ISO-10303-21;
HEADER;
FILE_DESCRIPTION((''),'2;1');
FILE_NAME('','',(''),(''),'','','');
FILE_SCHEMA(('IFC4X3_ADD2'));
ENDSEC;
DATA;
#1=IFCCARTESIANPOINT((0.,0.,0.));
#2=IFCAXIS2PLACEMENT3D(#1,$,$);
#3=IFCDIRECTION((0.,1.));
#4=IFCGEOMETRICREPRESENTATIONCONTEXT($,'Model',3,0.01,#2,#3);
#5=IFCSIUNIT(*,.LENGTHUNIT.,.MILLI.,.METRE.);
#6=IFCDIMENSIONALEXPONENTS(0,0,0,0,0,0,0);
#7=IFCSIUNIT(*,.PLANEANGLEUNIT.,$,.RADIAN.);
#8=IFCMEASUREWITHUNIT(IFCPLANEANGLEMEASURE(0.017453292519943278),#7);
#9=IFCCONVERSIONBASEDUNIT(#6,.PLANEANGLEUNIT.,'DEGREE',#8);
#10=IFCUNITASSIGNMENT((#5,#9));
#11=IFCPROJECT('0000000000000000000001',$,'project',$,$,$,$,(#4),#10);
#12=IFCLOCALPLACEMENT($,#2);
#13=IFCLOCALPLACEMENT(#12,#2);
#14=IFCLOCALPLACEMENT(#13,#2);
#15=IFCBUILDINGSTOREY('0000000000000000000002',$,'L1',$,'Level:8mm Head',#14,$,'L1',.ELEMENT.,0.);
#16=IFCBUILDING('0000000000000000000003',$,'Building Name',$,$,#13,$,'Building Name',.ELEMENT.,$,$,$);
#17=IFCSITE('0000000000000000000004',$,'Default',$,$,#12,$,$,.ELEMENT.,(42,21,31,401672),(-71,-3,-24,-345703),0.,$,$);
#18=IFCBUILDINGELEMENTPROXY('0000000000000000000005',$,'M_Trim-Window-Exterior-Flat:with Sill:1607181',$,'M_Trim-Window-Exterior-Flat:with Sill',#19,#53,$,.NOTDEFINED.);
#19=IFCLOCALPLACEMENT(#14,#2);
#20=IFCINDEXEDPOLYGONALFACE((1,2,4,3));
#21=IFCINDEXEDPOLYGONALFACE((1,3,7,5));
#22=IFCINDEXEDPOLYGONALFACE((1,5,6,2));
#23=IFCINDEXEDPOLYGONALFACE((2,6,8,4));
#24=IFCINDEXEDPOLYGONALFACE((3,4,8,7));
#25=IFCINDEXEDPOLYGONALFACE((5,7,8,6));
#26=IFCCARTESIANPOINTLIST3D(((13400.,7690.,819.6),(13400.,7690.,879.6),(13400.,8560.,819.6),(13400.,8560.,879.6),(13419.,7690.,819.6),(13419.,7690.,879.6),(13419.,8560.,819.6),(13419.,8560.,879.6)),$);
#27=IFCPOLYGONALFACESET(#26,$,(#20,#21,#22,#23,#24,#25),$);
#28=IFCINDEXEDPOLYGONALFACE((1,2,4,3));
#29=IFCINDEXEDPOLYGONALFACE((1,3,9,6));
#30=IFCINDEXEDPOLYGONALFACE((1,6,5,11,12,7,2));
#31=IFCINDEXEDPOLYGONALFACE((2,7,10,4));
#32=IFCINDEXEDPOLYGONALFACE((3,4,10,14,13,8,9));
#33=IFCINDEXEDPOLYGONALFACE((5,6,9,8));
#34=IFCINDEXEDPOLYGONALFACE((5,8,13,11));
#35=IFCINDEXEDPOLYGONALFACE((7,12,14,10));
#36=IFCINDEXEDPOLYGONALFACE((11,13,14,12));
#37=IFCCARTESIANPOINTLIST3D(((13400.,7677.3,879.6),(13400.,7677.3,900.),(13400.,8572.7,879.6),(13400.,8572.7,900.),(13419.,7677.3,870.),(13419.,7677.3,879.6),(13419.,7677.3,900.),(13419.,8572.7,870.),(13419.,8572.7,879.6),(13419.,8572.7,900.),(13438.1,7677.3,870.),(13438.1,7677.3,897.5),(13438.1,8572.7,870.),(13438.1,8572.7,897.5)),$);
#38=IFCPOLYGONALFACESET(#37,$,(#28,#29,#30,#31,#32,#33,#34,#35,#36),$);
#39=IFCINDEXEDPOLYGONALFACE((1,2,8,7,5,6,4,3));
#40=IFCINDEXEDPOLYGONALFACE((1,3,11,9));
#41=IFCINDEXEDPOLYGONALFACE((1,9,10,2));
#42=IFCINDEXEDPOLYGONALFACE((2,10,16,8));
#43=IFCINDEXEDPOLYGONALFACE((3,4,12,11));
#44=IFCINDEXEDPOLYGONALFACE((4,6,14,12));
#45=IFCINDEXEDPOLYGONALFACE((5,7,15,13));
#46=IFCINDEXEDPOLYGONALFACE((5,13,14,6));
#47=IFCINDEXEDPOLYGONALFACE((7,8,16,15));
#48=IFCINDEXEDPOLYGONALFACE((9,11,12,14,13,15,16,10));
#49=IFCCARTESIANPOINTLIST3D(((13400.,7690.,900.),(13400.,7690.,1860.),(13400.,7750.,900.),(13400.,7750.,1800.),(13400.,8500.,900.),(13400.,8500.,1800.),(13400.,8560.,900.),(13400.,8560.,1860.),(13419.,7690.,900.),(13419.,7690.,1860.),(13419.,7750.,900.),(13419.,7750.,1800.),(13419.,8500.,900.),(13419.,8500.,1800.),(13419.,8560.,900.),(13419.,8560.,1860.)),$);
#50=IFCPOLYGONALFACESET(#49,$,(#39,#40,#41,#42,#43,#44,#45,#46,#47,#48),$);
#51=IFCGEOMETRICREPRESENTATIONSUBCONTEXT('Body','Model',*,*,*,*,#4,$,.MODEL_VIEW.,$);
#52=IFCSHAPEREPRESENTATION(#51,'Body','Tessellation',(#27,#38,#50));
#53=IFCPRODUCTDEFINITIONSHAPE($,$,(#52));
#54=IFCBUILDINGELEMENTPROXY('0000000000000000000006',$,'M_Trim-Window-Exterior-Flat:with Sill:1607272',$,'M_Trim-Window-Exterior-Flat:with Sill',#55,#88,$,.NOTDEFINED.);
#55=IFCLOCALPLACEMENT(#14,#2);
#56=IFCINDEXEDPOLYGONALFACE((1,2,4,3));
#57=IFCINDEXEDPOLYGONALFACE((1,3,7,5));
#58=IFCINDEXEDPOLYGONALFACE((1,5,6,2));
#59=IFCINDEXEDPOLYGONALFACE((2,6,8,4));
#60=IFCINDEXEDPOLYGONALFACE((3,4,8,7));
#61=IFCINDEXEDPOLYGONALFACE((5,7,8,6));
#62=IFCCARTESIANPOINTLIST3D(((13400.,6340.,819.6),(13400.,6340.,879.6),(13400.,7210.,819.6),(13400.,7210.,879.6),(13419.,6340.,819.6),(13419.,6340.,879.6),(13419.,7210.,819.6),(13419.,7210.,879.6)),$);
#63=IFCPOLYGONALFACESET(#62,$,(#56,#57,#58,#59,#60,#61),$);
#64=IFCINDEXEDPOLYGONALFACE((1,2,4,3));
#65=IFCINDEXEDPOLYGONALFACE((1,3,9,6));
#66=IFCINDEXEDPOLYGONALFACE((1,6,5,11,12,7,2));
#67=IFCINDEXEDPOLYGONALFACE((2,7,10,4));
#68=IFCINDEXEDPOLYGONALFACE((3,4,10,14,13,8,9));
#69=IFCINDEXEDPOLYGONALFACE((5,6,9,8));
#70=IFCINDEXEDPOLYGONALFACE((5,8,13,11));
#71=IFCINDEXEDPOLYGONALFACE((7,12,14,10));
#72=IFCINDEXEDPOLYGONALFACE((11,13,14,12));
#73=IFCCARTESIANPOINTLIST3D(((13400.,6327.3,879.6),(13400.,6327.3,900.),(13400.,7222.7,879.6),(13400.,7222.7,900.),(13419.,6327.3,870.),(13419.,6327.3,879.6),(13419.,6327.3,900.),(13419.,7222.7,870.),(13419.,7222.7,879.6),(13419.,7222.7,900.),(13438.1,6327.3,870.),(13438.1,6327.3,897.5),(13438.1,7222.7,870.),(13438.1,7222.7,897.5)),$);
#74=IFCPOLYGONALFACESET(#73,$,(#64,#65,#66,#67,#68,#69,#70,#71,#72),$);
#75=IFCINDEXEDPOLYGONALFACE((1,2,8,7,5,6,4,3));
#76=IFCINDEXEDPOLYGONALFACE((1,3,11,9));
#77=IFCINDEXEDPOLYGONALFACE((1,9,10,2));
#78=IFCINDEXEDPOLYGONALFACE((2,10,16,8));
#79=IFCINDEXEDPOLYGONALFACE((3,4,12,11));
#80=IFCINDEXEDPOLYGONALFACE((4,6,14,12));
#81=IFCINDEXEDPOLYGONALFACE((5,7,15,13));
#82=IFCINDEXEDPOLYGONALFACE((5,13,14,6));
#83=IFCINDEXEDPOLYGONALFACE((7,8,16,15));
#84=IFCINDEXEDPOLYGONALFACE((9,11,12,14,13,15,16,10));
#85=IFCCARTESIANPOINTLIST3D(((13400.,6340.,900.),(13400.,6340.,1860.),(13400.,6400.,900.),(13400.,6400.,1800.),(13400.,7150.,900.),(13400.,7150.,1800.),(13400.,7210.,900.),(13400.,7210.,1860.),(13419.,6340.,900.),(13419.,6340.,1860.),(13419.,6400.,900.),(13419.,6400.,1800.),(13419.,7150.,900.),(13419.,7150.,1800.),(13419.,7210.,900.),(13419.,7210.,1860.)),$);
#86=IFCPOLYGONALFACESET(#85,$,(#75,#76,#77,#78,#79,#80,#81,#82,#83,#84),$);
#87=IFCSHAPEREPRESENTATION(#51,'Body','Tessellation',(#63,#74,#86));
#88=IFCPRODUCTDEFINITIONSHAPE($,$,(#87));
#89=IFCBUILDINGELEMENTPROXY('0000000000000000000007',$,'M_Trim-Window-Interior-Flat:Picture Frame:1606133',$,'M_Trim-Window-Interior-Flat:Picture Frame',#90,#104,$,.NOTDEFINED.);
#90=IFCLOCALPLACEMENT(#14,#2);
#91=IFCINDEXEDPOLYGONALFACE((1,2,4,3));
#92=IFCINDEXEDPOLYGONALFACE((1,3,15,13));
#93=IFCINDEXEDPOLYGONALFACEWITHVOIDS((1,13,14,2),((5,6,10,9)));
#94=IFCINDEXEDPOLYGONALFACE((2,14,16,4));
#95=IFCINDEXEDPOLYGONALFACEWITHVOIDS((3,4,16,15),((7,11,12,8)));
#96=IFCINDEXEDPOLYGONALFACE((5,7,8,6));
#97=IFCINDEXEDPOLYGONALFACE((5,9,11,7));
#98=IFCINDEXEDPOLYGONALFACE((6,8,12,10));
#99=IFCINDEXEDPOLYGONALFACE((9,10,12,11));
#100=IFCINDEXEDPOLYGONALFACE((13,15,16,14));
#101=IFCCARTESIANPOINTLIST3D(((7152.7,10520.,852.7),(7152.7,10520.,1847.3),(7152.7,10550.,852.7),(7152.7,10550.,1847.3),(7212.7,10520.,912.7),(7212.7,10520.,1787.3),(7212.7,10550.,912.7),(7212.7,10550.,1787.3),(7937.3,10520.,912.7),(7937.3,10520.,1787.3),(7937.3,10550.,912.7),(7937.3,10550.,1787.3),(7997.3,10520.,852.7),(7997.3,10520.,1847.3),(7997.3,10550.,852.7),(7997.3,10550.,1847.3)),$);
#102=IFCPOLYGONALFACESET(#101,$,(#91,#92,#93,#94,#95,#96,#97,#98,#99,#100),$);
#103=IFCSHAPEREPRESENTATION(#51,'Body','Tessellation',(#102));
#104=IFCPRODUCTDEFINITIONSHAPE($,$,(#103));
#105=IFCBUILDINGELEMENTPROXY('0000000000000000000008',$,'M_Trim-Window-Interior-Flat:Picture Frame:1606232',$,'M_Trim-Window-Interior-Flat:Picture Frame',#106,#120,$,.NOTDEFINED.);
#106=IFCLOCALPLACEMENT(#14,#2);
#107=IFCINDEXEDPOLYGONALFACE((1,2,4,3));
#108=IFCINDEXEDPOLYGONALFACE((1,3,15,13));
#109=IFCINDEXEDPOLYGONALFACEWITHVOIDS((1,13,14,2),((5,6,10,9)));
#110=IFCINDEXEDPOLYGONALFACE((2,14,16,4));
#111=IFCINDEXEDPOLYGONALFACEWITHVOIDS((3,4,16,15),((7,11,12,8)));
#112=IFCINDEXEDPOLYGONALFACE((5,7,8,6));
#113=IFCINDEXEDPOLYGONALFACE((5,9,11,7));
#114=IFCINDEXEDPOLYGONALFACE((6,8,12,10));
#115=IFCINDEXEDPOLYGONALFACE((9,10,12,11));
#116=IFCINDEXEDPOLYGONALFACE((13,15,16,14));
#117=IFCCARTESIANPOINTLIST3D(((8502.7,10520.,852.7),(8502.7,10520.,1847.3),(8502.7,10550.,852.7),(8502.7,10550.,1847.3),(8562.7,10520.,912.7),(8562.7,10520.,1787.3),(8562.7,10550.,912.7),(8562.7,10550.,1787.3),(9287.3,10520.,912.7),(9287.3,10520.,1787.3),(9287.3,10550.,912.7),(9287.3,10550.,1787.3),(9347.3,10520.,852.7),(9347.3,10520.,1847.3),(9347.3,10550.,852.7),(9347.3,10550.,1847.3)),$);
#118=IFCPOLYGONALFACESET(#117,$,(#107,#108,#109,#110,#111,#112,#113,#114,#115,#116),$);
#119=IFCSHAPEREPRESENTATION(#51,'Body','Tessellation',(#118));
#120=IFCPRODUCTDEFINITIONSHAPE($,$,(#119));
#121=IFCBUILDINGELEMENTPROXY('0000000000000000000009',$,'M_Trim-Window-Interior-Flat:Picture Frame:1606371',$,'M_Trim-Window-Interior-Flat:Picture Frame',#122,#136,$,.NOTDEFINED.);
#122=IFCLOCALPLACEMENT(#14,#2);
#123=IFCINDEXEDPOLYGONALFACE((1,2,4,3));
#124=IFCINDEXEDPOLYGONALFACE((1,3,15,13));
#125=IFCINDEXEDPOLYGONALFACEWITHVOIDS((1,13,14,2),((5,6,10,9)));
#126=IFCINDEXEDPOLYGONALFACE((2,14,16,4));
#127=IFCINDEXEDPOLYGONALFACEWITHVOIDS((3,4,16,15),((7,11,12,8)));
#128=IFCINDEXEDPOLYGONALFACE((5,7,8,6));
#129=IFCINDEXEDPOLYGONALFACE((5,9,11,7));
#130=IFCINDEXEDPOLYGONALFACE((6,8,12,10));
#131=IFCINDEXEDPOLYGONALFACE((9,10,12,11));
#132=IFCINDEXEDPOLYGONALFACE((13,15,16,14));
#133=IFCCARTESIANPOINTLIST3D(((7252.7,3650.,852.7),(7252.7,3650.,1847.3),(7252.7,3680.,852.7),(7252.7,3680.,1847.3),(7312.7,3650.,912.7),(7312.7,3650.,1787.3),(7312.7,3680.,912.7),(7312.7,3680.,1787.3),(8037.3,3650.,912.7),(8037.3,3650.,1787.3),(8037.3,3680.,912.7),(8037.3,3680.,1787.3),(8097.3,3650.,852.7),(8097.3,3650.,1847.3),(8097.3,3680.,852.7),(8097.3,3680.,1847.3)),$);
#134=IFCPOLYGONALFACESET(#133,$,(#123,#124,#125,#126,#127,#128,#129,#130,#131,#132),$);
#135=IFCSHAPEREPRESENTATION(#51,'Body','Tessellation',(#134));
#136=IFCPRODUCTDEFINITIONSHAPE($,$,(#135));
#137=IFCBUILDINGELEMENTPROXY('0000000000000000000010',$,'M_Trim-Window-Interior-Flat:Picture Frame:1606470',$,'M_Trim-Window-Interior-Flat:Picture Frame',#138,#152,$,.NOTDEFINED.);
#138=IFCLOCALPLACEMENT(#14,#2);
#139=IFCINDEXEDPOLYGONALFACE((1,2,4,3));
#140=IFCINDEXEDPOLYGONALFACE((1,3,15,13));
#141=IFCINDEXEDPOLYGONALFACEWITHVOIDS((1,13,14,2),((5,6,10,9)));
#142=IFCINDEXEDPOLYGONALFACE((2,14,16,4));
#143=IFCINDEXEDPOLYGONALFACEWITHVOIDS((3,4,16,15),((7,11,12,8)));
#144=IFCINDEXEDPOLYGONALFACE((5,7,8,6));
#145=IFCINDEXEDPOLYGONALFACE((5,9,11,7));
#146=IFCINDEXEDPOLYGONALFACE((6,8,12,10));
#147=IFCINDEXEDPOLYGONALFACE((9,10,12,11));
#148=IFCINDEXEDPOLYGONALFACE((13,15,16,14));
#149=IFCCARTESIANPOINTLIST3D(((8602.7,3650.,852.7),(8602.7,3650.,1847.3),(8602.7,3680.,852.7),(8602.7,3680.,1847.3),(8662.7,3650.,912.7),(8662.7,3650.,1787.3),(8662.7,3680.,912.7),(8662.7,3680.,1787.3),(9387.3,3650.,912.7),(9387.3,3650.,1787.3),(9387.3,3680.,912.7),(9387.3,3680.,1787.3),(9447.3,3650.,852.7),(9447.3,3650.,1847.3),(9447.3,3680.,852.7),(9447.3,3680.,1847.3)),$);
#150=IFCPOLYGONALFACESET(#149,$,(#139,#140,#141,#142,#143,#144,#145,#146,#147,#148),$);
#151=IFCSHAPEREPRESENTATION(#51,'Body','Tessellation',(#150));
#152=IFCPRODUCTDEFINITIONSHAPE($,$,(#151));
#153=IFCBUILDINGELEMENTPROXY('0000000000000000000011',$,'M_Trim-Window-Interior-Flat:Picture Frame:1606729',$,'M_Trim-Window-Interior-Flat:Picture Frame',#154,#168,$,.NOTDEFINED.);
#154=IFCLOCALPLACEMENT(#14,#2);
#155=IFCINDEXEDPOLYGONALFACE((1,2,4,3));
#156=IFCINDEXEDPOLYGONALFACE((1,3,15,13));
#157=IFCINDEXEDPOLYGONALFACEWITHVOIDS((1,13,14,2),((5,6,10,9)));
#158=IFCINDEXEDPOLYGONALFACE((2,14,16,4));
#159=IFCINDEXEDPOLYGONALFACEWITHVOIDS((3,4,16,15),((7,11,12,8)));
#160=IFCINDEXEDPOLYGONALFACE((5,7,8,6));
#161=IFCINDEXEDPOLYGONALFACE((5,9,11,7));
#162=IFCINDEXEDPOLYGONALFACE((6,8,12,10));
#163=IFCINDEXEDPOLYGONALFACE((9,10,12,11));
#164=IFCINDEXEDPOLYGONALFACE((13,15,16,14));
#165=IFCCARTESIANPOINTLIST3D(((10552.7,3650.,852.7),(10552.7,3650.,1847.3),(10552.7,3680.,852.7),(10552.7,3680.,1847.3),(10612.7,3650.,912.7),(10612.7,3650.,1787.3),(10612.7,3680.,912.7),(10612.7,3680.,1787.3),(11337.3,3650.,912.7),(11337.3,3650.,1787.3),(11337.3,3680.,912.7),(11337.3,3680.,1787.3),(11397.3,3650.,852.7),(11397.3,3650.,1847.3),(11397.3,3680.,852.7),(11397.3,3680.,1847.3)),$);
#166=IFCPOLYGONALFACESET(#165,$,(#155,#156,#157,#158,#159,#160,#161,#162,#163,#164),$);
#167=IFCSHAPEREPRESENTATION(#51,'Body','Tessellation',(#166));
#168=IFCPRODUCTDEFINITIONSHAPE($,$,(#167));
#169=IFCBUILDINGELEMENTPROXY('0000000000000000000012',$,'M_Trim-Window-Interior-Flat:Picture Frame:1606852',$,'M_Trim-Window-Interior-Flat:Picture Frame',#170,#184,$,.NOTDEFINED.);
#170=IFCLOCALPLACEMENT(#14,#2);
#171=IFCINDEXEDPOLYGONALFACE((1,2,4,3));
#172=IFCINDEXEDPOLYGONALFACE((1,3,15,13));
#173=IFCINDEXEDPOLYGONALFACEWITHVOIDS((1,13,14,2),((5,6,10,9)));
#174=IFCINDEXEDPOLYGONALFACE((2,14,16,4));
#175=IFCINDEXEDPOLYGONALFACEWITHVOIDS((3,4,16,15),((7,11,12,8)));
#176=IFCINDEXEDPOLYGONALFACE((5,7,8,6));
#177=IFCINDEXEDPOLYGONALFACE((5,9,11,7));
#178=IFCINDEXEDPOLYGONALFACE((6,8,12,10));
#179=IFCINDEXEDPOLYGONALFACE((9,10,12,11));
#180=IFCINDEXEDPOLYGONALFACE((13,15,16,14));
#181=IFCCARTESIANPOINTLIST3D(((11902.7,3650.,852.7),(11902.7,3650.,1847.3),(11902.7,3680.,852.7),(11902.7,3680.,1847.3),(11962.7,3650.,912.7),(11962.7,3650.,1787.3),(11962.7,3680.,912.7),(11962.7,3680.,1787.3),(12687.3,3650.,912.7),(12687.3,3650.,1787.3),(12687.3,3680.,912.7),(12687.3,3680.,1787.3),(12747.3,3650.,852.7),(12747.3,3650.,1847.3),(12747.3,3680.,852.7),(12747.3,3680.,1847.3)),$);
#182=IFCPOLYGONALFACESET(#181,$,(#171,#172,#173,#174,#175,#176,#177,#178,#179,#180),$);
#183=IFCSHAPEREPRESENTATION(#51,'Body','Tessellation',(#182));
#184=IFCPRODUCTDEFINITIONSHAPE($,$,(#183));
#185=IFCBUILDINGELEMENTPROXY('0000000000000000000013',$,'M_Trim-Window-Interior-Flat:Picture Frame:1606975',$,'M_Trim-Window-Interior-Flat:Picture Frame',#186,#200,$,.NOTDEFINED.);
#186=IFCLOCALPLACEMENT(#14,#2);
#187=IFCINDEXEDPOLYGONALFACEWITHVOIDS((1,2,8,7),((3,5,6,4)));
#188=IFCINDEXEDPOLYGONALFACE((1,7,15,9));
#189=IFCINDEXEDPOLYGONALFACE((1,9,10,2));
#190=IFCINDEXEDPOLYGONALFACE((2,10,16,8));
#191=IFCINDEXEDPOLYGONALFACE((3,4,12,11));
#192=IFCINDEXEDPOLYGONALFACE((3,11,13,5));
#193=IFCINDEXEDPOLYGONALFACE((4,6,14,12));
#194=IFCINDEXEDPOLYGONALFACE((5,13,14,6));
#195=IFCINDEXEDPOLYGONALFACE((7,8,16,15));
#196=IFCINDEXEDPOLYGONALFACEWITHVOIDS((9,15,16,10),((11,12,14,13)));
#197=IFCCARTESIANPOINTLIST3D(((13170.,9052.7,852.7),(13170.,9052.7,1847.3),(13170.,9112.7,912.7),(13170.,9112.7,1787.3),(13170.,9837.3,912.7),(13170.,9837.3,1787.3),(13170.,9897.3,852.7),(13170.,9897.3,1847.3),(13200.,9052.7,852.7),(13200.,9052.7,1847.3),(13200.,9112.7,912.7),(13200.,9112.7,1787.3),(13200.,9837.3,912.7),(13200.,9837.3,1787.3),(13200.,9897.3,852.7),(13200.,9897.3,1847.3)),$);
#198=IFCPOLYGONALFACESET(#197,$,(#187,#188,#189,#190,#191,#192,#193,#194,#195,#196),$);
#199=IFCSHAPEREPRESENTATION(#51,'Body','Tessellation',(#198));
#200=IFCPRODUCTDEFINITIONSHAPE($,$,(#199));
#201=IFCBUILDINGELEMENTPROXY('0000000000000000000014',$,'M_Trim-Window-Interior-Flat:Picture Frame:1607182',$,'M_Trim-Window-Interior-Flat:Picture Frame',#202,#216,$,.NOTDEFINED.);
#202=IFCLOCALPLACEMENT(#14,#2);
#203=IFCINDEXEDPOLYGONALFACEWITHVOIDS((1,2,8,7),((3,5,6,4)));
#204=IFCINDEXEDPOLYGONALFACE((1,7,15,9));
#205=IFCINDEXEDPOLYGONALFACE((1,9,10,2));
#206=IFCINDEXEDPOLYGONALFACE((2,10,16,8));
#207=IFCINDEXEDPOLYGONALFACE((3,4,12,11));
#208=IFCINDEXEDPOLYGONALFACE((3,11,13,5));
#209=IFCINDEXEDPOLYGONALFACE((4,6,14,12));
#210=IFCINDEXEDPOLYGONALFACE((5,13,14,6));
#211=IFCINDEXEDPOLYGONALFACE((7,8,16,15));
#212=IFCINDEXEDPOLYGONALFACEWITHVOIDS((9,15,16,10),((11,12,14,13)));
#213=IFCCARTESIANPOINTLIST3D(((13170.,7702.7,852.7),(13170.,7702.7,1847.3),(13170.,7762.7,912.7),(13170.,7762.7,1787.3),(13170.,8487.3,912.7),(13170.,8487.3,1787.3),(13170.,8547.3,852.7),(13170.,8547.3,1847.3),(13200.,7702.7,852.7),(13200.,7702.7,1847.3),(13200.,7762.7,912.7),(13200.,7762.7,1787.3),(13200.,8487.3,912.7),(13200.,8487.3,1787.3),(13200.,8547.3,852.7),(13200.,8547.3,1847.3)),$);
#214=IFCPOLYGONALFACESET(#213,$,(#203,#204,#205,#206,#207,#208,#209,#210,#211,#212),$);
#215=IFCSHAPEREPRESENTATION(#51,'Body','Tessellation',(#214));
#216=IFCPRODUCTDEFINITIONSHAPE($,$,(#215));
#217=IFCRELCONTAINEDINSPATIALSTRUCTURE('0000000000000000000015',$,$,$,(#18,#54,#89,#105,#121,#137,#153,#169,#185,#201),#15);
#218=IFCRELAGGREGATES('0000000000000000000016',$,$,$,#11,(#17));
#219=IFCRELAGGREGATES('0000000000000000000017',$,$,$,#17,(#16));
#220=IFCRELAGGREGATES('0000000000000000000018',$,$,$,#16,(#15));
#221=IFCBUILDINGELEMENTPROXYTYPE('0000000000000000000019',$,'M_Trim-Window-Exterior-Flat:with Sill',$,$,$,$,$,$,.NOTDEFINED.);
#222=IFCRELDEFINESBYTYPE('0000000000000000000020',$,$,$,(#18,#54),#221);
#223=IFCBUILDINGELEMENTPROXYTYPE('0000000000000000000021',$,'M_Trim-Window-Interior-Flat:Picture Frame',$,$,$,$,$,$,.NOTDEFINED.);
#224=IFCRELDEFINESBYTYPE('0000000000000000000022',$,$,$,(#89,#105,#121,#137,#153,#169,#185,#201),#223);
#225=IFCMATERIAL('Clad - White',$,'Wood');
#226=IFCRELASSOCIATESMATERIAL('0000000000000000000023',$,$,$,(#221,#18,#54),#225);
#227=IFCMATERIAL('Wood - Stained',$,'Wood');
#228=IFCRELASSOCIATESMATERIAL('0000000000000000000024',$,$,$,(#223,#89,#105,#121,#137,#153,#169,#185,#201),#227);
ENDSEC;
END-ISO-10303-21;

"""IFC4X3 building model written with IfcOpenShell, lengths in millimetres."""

from ifc_helpers import new_model, entity, si_unit, converted_unit, direction, frame, frame_2d, origin, place, context, subcontext, project, spatial, polyline, rectangle, outline, extrude, source, transform, mapped, material, type_object, type_shapes, element, save


model = new_model("IFC4X3")

# Units and contexts
model_context = context("Model", 3, precision=0.01, world=origin(), true_north=direction((0.0, 1.0)))
body_context = subcontext(model_context, "Body", "Model", "MODEL_VIEW")
ifc_project = project(units=[si_unit("LENGTHUNIT", "METRE", prefix="MILLI"), converted_unit("PLANEANGLEUNIT", "DEGREE", entity("IfcPlaneAngleMeasure", 0.017453292519943278), si_unit("PLANEANGLEUNIT", "RADIAN"), dimensions=[0, 0, 0, 0, 0, 0, 0])], contexts=[model_context])

# Site, building, storey
site_placement = place(None, origin())
site = spatial("IfcSite", under=ifc_project, at=site_placement, Name="Default", CompositionType="ELEMENT", RefLatitude=(42, 21, 31, 401672), RefLongitude=(-71, -3, -24, -345703), RefElevation=0.0)
building_placement = place(site_placement, origin())
building = spatial("IfcBuilding", under=site, at=building_placement, Name="Building Name", LongName="Building Name", CompositionType="ELEMENT")
storey_placement = place(building_placement, origin())
storey = spatial("IfcBuildingStorey", under=building, at=storey_placement, Name="L1", ObjectType="Level:8mm Head", LongName="L1", CompositionType="ELEMENT", Elevation=0.0)

# Building element proxies
ifc_material_1 = material(Name="Clad - White", Category="Wood")
ifc_material_2 = material(Name="Wood - Stained", Category="Wood")
building_element_proxy_type_1 = type_object("IfcBuildingElementProxyType", Name="M_Trim-Window-Exterior-Flat:with Sill", PredefinedType="NOTDEFINED", material=ifc_material_1)
shared_shape_1 = source(origin(), body_context, "Body", "SweptSolid", [
    extrude(rectangle(XDim=870.0, YDim=60.0, at=frame_2d((0.0, 0.0), x_axis=(1.0, 0.0))), frame((0.0, -950.4, 0.0), z_axis=(0.0, 0.0, 1.0), x_axis=(-1.0, 0.0, 0.0)), (0.0, 0.0, 1.0), 19.0),
    extrude(outline(polyline([(-19.0, -15.2), (0.0, -15.2), (0.0, -5.7), (19.0, -5.7), (19.0, 14.8), (0.0, 14.8), (-19.0, 12.3), (-19.0, -15.2)])), frame((-447.7, -914.8, 19.0), z_axis=(1.0, 0.0, 0.0), x_axis=(0.0, 0.0, -1.0)), (0.0, 0.0, 1.0), 895.4),
    extrude(outline(polyline([(-495.0, -435.0), (465.0, -435.0), (465.0, -375.0), (-435.0, -375.0), (-435.0, 375.0), (465.0, 375.0), (465.0, 435.0), (-495.0, 435.0), (-495.0, -435.0)])), frame((0.0, -435.0, 0.0), z_axis=(0.0, 0.0, 1.0), x_axis=(0.0, -1.0, 0.0)), (0.0, 0.0, 1.0), 19.0),
])
type_shapes(building_element_proxy_type_1, [shared_shape_1])
for number, where, z_axis, x_axis, name in (
    (1, (13400.0, 8125.0, 1800.0), (1.0, 0.0, 0.0), (0.0, 1.0, 0.0), "M_Trim-Window-Exterior-Flat:with Sill:1607181"),
    (2, (13400.0, 6775.0, 1800.0), (1.0, 0.0, 0.0), (0.0, 1.0, 0.0), "M_Trim-Window-Exterior-Flat:with Sill:1607272"),
):
    element("IfcBuildingElementProxy", number, at=place(storey_placement, frame(where, z_axis=z_axis, x_axis=x_axis)), inside=storey, type_object=building_element_proxy_type_1, material=ifc_material_1, Name=name, ObjectType="M_Trim-Window-Exterior-Flat:with Sill", PredefinedType="NOTDEFINED", context=body_context, shape_type="MappedRepresentation", body=[
        mapped(shared_shape_1, transform((0.0, 0.0, 0.0), scale=1.0)),
    ])
building_element_proxy_type_2 = type_object("IfcBuildingElementProxyType", Name="M_Trim-Window-Interior-Flat:Picture Frame", PredefinedType="NOTDEFINED", material=ifc_material_2)
shared_shape_2 = source(origin(), body_context, "Body", "SweptSolid", [
    extrude(outline(polyline([(-422.3, -497.3), (422.3, -497.3), (422.3, 497.3), (-422.3, 497.3), (-422.3, -497.3)]), holes=[polyline([(-362.3, -437.3), (-362.3, 437.3), (362.3, 437.3), (362.3, -437.3), (-362.3, -437.3)])]), frame((0.0, -450.0, 0.0), z_axis=(0.0, 0.0, 1.0), x_axis=(-1.0, 0.0, 0.0)), (0.0, 0.0, 1.0), 30.0),
])
type_shapes(building_element_proxy_type_2, [shared_shape_2])
for number, where, z_axis, x_axis, name in (
    (3, (7575.0, 10550.0, 1800.0), (0.0, -1.0, 0.0), (1.0, 0.0, 0.0), "M_Trim-Window-Interior-Flat:Picture Frame:1606133"),
    (4, (8925.0, 10550.0, 1800.0), (0.0, -1.0, 0.0), (1.0, 0.0, 0.0), "M_Trim-Window-Interior-Flat:Picture Frame:1606232"),
    (5, (7675.0, 3650.0, 1800.0), (0.0, 1.0, 0.0), (-1.0, 0.0, 0.0), "M_Trim-Window-Interior-Flat:Picture Frame:1606371"),
    (6, (9025.0, 3650.0, 1800.0), (0.0, 1.0, 0.0), (-1.0, 0.0, 0.0), "M_Trim-Window-Interior-Flat:Picture Frame:1606470"),
    (7, (10975.0, 3650.0, 1800.0), (0.0, 1.0, 0.0), (-1.0, 0.0, 0.0), "M_Trim-Window-Interior-Flat:Picture Frame:1606729"),
    (8, (12325.0, 3650.0, 1800.0), (0.0, 1.0, 0.0), (-1.0, 0.0, 0.0), "M_Trim-Window-Interior-Flat:Picture Frame:1606852"),
    (9, (13200.0, 9475.0, 1800.0), (-1.0, 0.0, 0.0), (0.0, -1.0, 0.0), "M_Trim-Window-Interior-Flat:Picture Frame:1606975"),
    (10, (13200.0, 8125.0, 1800.0), (-1.0, 0.0, 0.0), (0.0, -1.0, 0.0), "M_Trim-Window-Interior-Flat:Picture Frame:1607182"),
):
    element("IfcBuildingElementProxy", number, at=place(storey_placement, frame(where, z_axis=z_axis, x_axis=x_axis)), inside=storey, type_object=building_element_proxy_type_2, material=ifc_material_2, Name=name, ObjectType="M_Trim-Window-Interior-Flat:Picture Frame", PredefinedType="NOTDEFINED", context=body_context, shape_type="MappedRepresentation", body=[
        mapped(shared_shape_2, transform((0.0, 0.0, 0.0), scale=1.0)),
    ])

save(model, "model.ifc")
